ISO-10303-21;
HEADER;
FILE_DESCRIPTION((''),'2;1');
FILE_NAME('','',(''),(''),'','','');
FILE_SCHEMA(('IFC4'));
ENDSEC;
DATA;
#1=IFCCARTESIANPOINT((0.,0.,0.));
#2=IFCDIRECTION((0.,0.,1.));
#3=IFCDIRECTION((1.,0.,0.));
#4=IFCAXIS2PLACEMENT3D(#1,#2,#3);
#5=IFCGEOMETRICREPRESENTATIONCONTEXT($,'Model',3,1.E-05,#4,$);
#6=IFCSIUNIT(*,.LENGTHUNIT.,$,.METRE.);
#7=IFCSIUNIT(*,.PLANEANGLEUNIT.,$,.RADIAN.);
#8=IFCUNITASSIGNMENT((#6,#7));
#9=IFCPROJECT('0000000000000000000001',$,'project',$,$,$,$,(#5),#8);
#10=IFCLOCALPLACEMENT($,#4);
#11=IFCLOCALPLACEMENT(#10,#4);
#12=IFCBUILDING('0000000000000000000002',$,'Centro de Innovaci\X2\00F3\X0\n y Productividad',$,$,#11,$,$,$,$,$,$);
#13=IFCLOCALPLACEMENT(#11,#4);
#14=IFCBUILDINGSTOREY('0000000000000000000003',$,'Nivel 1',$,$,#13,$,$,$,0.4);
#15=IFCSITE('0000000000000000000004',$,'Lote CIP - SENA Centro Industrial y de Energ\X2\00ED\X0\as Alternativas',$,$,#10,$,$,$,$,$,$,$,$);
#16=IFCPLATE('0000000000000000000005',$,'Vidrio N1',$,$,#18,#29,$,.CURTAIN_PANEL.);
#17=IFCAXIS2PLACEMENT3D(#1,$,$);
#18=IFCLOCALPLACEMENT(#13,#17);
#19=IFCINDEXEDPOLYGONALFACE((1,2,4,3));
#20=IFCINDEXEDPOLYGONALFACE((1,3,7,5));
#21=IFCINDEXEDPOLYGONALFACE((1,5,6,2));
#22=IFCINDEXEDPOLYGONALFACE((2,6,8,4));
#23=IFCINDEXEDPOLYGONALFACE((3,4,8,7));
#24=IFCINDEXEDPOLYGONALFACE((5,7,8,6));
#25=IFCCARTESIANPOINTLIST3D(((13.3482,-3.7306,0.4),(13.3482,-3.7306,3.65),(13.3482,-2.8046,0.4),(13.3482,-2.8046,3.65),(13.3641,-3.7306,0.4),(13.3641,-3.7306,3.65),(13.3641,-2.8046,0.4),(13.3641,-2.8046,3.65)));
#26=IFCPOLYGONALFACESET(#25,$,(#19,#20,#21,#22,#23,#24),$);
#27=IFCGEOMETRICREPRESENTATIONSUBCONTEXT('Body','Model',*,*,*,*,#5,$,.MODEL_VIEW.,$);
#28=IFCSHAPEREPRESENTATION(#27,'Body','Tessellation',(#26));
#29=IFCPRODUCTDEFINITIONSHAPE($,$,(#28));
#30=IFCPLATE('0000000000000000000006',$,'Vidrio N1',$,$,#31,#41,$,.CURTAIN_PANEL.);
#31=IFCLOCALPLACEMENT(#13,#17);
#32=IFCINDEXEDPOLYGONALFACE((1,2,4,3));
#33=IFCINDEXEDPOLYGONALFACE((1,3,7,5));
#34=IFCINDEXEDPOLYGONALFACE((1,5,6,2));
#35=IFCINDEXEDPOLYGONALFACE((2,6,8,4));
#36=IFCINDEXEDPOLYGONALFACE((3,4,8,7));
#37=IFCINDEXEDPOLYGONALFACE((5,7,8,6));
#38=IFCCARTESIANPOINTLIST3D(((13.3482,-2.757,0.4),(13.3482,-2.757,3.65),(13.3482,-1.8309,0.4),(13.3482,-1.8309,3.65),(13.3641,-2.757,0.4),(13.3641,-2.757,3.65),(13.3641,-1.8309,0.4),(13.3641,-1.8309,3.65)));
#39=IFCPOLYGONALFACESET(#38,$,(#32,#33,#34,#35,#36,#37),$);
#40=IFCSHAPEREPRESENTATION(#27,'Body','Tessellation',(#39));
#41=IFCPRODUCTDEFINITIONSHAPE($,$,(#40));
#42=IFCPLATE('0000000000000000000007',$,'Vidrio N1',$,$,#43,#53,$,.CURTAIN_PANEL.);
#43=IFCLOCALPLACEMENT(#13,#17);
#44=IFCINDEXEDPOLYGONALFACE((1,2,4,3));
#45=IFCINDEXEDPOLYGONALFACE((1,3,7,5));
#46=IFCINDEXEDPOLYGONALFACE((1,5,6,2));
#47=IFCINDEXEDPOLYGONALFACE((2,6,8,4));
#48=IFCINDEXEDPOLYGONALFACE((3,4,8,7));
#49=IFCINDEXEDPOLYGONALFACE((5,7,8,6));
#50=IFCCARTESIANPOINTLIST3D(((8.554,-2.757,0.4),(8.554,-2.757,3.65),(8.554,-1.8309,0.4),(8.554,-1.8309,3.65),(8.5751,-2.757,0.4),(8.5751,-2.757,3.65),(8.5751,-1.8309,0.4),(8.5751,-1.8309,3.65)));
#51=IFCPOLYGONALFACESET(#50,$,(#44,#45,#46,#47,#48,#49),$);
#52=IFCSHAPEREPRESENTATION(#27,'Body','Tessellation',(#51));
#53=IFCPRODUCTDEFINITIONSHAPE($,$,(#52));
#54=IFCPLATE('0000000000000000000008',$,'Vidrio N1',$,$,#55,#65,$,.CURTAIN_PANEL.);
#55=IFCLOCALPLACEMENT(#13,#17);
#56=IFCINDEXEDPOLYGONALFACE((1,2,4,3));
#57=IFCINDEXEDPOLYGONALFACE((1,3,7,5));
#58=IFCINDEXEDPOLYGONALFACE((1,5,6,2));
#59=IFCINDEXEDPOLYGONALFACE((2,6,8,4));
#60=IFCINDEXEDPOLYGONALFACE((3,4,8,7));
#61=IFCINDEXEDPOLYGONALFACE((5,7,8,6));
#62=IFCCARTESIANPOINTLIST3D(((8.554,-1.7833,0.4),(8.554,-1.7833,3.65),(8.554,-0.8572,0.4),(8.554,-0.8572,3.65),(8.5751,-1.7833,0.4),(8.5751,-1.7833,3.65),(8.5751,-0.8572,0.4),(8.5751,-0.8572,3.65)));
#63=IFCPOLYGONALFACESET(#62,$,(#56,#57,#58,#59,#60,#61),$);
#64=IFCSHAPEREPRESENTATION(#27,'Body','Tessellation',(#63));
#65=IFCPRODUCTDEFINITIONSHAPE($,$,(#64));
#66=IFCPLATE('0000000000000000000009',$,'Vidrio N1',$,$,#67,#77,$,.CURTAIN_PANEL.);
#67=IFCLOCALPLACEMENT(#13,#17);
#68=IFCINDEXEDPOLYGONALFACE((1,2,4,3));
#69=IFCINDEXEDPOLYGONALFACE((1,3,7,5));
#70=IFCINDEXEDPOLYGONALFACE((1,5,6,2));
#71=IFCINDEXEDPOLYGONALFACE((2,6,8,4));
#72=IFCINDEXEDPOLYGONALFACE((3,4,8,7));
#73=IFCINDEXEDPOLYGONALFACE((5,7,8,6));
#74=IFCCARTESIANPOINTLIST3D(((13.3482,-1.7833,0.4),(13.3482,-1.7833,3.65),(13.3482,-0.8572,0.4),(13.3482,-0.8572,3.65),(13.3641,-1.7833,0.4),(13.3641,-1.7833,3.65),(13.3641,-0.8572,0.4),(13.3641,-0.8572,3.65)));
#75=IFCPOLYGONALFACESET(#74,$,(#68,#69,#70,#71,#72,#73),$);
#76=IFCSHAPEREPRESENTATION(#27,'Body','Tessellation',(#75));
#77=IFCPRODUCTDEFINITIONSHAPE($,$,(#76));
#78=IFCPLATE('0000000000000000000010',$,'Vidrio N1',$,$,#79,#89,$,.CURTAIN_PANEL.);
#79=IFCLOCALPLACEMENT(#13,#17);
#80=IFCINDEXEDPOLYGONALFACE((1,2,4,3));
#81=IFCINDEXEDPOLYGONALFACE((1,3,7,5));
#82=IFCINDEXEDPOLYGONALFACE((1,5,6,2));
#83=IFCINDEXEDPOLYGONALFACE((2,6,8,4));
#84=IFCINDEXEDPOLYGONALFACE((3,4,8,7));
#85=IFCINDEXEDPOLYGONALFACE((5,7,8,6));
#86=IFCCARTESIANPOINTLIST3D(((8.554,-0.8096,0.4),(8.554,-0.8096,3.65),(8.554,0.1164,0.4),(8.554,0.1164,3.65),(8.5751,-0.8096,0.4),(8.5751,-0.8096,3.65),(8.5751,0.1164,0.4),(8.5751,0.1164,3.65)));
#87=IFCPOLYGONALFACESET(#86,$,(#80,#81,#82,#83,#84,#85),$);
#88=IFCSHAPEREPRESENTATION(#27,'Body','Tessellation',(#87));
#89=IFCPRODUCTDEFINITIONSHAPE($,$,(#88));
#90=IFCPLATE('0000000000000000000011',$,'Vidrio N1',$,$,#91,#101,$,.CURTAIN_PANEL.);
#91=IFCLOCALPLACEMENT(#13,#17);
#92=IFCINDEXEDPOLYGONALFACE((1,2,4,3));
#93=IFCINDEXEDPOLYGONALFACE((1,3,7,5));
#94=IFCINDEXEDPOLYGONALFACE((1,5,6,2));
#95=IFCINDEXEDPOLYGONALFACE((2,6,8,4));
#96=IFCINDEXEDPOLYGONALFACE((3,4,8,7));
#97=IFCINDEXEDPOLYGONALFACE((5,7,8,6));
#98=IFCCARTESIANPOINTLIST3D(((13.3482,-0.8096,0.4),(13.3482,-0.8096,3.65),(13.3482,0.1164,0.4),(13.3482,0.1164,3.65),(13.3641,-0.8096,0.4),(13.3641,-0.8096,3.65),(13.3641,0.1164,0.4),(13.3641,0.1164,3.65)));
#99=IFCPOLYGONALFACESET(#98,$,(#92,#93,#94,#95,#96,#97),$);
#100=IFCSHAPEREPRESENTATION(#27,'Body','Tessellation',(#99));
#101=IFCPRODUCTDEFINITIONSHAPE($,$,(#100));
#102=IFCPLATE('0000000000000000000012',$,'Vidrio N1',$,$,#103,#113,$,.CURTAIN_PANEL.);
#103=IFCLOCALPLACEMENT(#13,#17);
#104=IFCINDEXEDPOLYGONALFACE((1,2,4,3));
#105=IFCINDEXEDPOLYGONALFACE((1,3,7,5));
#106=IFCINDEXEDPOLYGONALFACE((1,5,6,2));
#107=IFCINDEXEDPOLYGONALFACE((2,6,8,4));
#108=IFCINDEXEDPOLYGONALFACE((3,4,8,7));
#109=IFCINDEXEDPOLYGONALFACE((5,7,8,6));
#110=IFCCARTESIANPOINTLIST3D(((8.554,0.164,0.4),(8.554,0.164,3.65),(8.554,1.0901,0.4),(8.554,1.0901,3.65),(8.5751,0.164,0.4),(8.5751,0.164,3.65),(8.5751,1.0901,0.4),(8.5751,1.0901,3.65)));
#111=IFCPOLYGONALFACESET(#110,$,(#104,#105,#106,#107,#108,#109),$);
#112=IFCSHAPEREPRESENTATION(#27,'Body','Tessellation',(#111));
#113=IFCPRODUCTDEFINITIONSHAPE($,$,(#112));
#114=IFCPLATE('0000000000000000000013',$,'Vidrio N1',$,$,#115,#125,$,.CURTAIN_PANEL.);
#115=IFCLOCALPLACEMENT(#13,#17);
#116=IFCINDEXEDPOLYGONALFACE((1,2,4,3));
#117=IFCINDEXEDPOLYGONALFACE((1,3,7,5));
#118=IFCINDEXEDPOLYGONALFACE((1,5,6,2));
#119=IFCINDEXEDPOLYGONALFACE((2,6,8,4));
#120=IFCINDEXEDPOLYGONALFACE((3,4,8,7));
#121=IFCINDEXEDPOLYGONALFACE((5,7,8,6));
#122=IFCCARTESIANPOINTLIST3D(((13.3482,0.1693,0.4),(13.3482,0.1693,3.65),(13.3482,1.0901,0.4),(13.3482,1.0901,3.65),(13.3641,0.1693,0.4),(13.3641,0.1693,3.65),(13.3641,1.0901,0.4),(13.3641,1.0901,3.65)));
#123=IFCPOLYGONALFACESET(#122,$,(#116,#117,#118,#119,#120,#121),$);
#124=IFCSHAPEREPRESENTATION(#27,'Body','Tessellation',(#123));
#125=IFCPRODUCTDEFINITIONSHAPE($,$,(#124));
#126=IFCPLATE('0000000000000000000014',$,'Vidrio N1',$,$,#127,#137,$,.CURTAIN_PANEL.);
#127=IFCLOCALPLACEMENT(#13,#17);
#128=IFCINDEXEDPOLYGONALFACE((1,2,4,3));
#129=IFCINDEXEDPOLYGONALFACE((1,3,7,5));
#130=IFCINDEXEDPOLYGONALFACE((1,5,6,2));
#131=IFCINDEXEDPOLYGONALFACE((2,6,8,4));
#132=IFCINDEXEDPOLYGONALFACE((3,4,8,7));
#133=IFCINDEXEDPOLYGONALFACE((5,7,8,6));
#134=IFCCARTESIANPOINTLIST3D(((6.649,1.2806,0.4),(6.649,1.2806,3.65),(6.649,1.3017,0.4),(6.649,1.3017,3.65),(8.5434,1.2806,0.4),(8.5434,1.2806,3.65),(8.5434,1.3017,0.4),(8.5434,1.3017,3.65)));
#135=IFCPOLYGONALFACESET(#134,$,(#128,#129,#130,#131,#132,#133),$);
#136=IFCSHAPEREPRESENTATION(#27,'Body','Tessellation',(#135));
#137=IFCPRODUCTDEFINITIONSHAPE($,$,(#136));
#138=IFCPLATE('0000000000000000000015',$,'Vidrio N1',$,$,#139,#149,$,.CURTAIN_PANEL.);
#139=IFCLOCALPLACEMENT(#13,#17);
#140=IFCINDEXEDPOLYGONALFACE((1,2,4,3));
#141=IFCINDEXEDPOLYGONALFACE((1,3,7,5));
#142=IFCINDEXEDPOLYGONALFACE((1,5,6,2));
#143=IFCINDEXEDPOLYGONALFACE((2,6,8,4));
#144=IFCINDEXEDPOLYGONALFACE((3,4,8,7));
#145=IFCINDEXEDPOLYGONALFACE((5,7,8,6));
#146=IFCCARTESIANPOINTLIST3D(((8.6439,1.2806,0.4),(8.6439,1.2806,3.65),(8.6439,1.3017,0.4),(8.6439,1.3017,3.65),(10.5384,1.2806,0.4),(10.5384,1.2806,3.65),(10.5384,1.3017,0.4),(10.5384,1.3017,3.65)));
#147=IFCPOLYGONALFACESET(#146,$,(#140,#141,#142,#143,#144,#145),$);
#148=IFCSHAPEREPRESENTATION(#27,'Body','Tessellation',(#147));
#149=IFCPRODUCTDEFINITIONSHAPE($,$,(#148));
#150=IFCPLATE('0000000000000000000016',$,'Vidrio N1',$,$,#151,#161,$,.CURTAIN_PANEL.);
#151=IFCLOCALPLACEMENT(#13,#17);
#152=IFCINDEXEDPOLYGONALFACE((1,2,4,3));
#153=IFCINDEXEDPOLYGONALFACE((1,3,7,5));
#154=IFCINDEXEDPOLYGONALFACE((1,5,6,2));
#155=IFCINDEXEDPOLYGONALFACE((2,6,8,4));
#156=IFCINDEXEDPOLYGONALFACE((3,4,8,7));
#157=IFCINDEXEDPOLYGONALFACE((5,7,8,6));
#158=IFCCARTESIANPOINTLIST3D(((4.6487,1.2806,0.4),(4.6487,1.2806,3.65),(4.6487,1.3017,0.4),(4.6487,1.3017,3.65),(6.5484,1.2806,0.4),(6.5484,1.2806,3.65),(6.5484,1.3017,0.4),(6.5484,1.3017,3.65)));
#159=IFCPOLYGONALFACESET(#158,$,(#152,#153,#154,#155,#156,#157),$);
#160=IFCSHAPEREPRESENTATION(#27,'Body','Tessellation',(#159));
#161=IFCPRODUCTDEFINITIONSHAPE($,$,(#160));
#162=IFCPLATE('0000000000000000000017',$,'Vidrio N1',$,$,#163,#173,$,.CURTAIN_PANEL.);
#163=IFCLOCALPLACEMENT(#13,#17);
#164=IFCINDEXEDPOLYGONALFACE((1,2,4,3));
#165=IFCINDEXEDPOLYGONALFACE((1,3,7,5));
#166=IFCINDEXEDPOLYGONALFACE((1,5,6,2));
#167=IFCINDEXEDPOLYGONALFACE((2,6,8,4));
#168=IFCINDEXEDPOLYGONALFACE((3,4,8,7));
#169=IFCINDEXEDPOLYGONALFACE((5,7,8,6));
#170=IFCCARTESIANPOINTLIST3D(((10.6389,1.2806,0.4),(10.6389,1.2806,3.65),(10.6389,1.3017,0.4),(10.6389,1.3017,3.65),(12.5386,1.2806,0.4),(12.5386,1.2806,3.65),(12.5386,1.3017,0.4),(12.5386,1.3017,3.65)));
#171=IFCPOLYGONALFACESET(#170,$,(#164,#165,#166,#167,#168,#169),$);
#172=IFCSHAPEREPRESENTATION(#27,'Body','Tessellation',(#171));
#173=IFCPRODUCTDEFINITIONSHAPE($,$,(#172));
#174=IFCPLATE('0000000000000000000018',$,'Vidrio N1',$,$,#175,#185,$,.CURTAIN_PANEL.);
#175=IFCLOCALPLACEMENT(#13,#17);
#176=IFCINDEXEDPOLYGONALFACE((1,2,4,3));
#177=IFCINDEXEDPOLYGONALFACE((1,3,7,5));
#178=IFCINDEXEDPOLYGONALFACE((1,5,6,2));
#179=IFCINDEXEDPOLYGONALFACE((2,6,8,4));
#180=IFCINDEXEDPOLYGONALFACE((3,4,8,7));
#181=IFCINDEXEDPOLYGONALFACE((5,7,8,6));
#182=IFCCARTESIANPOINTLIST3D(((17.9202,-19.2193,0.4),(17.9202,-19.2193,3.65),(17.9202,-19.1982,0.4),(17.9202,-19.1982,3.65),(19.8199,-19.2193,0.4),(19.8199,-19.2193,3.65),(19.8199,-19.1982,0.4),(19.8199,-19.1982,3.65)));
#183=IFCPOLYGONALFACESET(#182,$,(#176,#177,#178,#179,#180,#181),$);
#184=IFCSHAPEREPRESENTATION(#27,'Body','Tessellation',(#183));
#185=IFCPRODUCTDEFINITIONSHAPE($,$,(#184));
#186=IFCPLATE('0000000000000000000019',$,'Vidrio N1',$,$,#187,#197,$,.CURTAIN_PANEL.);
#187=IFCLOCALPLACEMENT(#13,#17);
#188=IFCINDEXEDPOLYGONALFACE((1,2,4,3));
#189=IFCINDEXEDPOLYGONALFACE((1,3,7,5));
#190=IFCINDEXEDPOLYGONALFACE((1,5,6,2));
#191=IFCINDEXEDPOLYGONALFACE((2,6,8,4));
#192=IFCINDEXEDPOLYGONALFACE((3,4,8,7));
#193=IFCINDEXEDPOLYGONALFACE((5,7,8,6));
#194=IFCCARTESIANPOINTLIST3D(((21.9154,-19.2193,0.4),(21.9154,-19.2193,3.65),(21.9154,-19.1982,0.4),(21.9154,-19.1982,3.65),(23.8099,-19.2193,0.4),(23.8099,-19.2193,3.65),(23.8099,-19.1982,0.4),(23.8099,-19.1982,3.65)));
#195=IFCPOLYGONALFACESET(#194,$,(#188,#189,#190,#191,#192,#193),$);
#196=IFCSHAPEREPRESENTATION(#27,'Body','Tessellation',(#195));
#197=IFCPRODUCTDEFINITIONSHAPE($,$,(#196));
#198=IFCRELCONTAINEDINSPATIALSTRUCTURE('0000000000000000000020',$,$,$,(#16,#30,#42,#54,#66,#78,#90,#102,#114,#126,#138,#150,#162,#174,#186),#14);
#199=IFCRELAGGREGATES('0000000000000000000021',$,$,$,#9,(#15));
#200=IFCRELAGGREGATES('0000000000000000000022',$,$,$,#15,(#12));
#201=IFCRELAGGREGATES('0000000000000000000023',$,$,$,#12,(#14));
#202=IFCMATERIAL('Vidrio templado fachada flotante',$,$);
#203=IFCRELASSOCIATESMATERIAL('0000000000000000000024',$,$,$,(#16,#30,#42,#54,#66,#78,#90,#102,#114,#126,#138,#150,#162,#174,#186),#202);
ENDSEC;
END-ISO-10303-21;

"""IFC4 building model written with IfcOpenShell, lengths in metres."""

from ifc_helpers import new_model, si_unit, frame, origin_with_axes, place, context, subcontext, project, spatial, polyline, outline, extrude, material, element, save


model = new_model("IFC4")

# Units and contexts
model_context = context("Model", 3, precision=1e-05, world=origin_with_axes())
body_context = subcontext(model_context, "Body", "Model", "MODEL_VIEW")
ifc_project = project(units=[si_unit("LENGTHUNIT", "METRE"), si_unit("PLANEANGLEUNIT", "RADIAN")], contexts=[model_context])

# Site, building, storey
site_placement = place(None, origin_with_axes())
site = spatial("IfcSite", under=ifc_project, at=site_placement, Name="Lote CIP - SENA Centro Industrial y de Energías Alternativas")
building_placement = place(site_placement, origin_with_axes())
building = spatial("IfcBuilding", under=site, at=building_placement, Name="Centro de Innovación y Productividad")
storey_placement = place(building_placement, origin_with_axes())
storey = spatial("IfcBuildingStorey", under=building, at=storey_placement, Name="Nivel 1", Elevation=0.4)

# Plates
ifc_material = material(Name="Vidrio templado fachada flotante")
plate_1_placement = place(storey_placement, origin_with_axes())
element("IfcPlate", 1, at=plate_1_placement, inside=storey, material=ifc_material, Name="Vidrio N1", PredefinedType="CURTAIN_PANEL", context=body_context, shape_type="SweptSolid", body=[
    extrude(outline(polyline([(13.3482, -2.8046), (13.3641, -2.8046), (13.3641, -3.7306), (13.3482, -3.7306), (13.3482, -2.8046)])), frame((0.0, 0.0, 0.4)), (0.0, 0.0, 1.0), 3.25),
])
plate_2_placement = place(storey_placement, origin_with_axes())
element("IfcPlate", 2, at=plate_2_placement, inside=storey, material=ifc_material, Name="Vidrio N1", PredefinedType="CURTAIN_PANEL", context=body_context, shape_type="SweptSolid", body=[
    extrude(outline(polyline([(13.3641, -2.757), (13.3482, -2.757), (13.3482, -1.8309), (13.3641, -1.8309), (13.3641, -2.757)])), frame((0.0, 0.0, 0.4)), (0.0, 0.0, 1.0), 3.25),
])
plate_3_placement = place(storey_placement, origin_with_axes())
element("IfcPlate", 3, at=plate_3_placement, inside=storey, material=ifc_material, Name="Vidrio N1", PredefinedType="CURTAIN_PANEL", context=body_context, shape_type="SweptSolid", body=[
    extrude(outline(polyline([(8.554, -1.8309), (8.5751, -1.8309), (8.5751, -2.757), (8.554, -2.757), (8.554, -1.8309)])), frame((0.0, 0.0, 0.4)), (0.0, 0.0, 1.0), 3.25),
])
plate_4_placement = place(storey_placement, origin_with_axes())
element("IfcPlate", 4, at=plate_4_placement, inside=storey, material=ifc_material, Name="Vidrio N1", PredefinedType="CURTAIN_PANEL", context=body_context, shape_type="SweptSolid", body=[
    extrude(outline(polyline([(8.5751, -1.7833), (8.554, -1.7833), (8.554, -0.8572), (8.5751, -0.8572), (8.5751, -1.7833)])), frame((0.0, 0.0, 0.4)), (0.0, 0.0, 1.0), 3.25),
])
plate_5_placement = place(storey_placement, origin_with_axes())
element("IfcPlate", 5, at=plate_5_placement, inside=storey, material=ifc_material, Name="Vidrio N1", PredefinedType="CURTAIN_PANEL", context=body_context, shape_type="SweptSolid", body=[
    extrude(outline(polyline([(13.3482, -1.7833), (13.3482, -0.8572), (13.3641, -0.8572), (13.3641, -1.7833), (13.3482, -1.7833)])), frame((0.0, 0.0, 0.4)), (0.0, 0.0, 1.0), 3.25),
])
plate_6_placement = place(storey_placement, origin_with_axes())
element("IfcPlate", 6, at=plate_6_placement, inside=storey, material=ifc_material, Name="Vidrio N1", PredefinedType="CURTAIN_PANEL", context=body_context, shape_type="SweptSolid", body=[
    extrude(outline(polyline([(8.5751, -0.8096), (8.554, -0.8096), (8.554, 0.1164), (8.5751, 0.1164), (8.5751, -0.8096)])), frame((0.0, 0.0, 0.4)), (0.0, 0.0, 1.0), 3.25),
])
plate_7_placement = place(storey_placement, origin_with_axes())
element("IfcPlate", 7, at=plate_7_placement, inside=storey, material=ifc_material, Name="Vidrio N1", PredefinedType="CURTAIN_PANEL", context=body_context, shape_type="SweptSolid", body=[
    extrude(outline(polyline([(13.3482, 0.1164), (13.3641, 0.1164), (13.3641, -0.8096), (13.3482, -0.8096), (13.3482, 0.1164)])), frame((0.0, 0.0, 0.4)), (0.0, 0.0, 1.0), 3.25),
])
plate_8_placement = place(storey_placement, origin_with_axes())
element("IfcPlate", 8, at=plate_8_placement, inside=storey, material=ifc_material, Name="Vidrio N1", PredefinedType="CURTAIN_PANEL", context=body_context, shape_type="SweptSolid", body=[
    extrude(outline(polyline([(8.5751, 0.164), (8.554, 0.164), (8.554, 1.0901), (8.5751, 1.0901), (8.5751, 0.164)])), frame((0.0, 0.0, 0.4)), (0.0, 0.0, 1.0), 3.25),
])
plate_9_placement = place(storey_placement, origin_with_axes())
element("IfcPlate", 9, at=plate_9_placement, inside=storey, material=ifc_material, Name="Vidrio N1", PredefinedType="CURTAIN_PANEL", context=body_context, shape_type="SweptSolid", body=[
    extrude(outline(polyline([(13.3482, 1.0901), (13.3641, 1.0901), (13.3641, 0.1693), (13.3482, 0.1693), (13.3482, 1.0901)])), frame((0.0, 0.0, 0.4)), (0.0, 0.0, 1.0), 3.25),
])
plate_10_placement = place(storey_placement, origin_with_axes())
element("IfcPlate", 10, at=plate_10_placement, inside=storey, material=ifc_material, Name="Vidrio N1", PredefinedType="CURTAIN_PANEL", context=body_context, shape_type="SweptSolid", body=[
    extrude(outline(polyline([(6.649, 1.2806), (6.649, 1.3017), (8.5434, 1.3017), (8.5434, 1.2806), (6.649, 1.2806)])), frame((0.0, 0.0, 0.4)), (0.0, 0.0, 1.0), 3.25),
])
plate_11_placement = place(storey_placement, origin_with_axes())
element("IfcPlate", 11, at=plate_11_placement, inside=storey, material=ifc_material, Name="Vidrio N1", PredefinedType="CURTAIN_PANEL", context=body_context, shape_type="SweptSolid", body=[
    extrude(outline(polyline([(10.5384, 1.3017), (10.5384, 1.2806), (8.6439, 1.2806), (8.6439, 1.3017), (10.5384, 1.3017)])), frame((0.0, 0.0, 0.4)), (0.0, 0.0, 1.0), 3.25),
])
plate_12_placement = place(storey_placement, origin_with_axes())
element("IfcPlate", 12, at=plate_12_placement, inside=storey, material=ifc_material, Name="Vidrio N1", PredefinedType="CURTAIN_PANEL", context=body_context, shape_type="SweptSolid", body=[
    extrude(outline(polyline([(4.6487, 1.2806), (4.6487, 1.3017), (6.5484, 1.3017), (6.5484, 1.2806), (4.6487, 1.2806)])), frame((0.0, 0.0, 0.4)), (0.0, 0.0, 1.0), 3.25),
])
plate_13_placement = place(storey_placement, origin_with_axes())
element("IfcPlate", 13, at=plate_13_placement, inside=storey, material=ifc_material, Name="Vidrio N1", PredefinedType="CURTAIN_PANEL", context=body_context, shape_type="SweptSolid", body=[
    extrude(outline(polyline([(12.5386, 1.2806), (10.6389, 1.2806), (10.6389, 1.3017), (12.5386, 1.3017), (12.5386, 1.2806)])), frame((0.0, 0.0, 0.4)), (0.0, 0.0, 1.0), 3.25),
])
plate_14_placement = place(storey_placement, origin_with_axes())
element("IfcPlate", 14, at=plate_14_placement, inside=storey, material=ifc_material, Name="Vidrio N1", PredefinedType="CURTAIN_PANEL", context=body_context, shape_type="SweptSolid", body=[
    extrude(outline(polyline([(17.9202, -19.2193), (17.9202, -19.1982), (19.8199, -19.1982), (19.8199, -19.2193), (17.9202, -19.2193)])), frame((0.0, 0.0, 0.4)), (0.0, 0.0, 1.0), 3.25),
])
plate_15_placement = place(storey_placement, origin_with_axes())
element("IfcPlate", 15, at=plate_15_placement, inside=storey, material=ifc_material, Name="Vidrio N1", PredefinedType="CURTAIN_PANEL", context=body_context, shape_type="SweptSolid", body=[
    extrude(outline(polyline([(21.9154, -19.1982), (23.8099, -19.1982), (23.8099, -19.2193), (21.9154, -19.2193), (21.9154, -19.1982)])), frame((0.0, 0.0, 0.4)), (0.0, 0.0, 1.0), 3.25),
])

save(model, "model.ifc")
